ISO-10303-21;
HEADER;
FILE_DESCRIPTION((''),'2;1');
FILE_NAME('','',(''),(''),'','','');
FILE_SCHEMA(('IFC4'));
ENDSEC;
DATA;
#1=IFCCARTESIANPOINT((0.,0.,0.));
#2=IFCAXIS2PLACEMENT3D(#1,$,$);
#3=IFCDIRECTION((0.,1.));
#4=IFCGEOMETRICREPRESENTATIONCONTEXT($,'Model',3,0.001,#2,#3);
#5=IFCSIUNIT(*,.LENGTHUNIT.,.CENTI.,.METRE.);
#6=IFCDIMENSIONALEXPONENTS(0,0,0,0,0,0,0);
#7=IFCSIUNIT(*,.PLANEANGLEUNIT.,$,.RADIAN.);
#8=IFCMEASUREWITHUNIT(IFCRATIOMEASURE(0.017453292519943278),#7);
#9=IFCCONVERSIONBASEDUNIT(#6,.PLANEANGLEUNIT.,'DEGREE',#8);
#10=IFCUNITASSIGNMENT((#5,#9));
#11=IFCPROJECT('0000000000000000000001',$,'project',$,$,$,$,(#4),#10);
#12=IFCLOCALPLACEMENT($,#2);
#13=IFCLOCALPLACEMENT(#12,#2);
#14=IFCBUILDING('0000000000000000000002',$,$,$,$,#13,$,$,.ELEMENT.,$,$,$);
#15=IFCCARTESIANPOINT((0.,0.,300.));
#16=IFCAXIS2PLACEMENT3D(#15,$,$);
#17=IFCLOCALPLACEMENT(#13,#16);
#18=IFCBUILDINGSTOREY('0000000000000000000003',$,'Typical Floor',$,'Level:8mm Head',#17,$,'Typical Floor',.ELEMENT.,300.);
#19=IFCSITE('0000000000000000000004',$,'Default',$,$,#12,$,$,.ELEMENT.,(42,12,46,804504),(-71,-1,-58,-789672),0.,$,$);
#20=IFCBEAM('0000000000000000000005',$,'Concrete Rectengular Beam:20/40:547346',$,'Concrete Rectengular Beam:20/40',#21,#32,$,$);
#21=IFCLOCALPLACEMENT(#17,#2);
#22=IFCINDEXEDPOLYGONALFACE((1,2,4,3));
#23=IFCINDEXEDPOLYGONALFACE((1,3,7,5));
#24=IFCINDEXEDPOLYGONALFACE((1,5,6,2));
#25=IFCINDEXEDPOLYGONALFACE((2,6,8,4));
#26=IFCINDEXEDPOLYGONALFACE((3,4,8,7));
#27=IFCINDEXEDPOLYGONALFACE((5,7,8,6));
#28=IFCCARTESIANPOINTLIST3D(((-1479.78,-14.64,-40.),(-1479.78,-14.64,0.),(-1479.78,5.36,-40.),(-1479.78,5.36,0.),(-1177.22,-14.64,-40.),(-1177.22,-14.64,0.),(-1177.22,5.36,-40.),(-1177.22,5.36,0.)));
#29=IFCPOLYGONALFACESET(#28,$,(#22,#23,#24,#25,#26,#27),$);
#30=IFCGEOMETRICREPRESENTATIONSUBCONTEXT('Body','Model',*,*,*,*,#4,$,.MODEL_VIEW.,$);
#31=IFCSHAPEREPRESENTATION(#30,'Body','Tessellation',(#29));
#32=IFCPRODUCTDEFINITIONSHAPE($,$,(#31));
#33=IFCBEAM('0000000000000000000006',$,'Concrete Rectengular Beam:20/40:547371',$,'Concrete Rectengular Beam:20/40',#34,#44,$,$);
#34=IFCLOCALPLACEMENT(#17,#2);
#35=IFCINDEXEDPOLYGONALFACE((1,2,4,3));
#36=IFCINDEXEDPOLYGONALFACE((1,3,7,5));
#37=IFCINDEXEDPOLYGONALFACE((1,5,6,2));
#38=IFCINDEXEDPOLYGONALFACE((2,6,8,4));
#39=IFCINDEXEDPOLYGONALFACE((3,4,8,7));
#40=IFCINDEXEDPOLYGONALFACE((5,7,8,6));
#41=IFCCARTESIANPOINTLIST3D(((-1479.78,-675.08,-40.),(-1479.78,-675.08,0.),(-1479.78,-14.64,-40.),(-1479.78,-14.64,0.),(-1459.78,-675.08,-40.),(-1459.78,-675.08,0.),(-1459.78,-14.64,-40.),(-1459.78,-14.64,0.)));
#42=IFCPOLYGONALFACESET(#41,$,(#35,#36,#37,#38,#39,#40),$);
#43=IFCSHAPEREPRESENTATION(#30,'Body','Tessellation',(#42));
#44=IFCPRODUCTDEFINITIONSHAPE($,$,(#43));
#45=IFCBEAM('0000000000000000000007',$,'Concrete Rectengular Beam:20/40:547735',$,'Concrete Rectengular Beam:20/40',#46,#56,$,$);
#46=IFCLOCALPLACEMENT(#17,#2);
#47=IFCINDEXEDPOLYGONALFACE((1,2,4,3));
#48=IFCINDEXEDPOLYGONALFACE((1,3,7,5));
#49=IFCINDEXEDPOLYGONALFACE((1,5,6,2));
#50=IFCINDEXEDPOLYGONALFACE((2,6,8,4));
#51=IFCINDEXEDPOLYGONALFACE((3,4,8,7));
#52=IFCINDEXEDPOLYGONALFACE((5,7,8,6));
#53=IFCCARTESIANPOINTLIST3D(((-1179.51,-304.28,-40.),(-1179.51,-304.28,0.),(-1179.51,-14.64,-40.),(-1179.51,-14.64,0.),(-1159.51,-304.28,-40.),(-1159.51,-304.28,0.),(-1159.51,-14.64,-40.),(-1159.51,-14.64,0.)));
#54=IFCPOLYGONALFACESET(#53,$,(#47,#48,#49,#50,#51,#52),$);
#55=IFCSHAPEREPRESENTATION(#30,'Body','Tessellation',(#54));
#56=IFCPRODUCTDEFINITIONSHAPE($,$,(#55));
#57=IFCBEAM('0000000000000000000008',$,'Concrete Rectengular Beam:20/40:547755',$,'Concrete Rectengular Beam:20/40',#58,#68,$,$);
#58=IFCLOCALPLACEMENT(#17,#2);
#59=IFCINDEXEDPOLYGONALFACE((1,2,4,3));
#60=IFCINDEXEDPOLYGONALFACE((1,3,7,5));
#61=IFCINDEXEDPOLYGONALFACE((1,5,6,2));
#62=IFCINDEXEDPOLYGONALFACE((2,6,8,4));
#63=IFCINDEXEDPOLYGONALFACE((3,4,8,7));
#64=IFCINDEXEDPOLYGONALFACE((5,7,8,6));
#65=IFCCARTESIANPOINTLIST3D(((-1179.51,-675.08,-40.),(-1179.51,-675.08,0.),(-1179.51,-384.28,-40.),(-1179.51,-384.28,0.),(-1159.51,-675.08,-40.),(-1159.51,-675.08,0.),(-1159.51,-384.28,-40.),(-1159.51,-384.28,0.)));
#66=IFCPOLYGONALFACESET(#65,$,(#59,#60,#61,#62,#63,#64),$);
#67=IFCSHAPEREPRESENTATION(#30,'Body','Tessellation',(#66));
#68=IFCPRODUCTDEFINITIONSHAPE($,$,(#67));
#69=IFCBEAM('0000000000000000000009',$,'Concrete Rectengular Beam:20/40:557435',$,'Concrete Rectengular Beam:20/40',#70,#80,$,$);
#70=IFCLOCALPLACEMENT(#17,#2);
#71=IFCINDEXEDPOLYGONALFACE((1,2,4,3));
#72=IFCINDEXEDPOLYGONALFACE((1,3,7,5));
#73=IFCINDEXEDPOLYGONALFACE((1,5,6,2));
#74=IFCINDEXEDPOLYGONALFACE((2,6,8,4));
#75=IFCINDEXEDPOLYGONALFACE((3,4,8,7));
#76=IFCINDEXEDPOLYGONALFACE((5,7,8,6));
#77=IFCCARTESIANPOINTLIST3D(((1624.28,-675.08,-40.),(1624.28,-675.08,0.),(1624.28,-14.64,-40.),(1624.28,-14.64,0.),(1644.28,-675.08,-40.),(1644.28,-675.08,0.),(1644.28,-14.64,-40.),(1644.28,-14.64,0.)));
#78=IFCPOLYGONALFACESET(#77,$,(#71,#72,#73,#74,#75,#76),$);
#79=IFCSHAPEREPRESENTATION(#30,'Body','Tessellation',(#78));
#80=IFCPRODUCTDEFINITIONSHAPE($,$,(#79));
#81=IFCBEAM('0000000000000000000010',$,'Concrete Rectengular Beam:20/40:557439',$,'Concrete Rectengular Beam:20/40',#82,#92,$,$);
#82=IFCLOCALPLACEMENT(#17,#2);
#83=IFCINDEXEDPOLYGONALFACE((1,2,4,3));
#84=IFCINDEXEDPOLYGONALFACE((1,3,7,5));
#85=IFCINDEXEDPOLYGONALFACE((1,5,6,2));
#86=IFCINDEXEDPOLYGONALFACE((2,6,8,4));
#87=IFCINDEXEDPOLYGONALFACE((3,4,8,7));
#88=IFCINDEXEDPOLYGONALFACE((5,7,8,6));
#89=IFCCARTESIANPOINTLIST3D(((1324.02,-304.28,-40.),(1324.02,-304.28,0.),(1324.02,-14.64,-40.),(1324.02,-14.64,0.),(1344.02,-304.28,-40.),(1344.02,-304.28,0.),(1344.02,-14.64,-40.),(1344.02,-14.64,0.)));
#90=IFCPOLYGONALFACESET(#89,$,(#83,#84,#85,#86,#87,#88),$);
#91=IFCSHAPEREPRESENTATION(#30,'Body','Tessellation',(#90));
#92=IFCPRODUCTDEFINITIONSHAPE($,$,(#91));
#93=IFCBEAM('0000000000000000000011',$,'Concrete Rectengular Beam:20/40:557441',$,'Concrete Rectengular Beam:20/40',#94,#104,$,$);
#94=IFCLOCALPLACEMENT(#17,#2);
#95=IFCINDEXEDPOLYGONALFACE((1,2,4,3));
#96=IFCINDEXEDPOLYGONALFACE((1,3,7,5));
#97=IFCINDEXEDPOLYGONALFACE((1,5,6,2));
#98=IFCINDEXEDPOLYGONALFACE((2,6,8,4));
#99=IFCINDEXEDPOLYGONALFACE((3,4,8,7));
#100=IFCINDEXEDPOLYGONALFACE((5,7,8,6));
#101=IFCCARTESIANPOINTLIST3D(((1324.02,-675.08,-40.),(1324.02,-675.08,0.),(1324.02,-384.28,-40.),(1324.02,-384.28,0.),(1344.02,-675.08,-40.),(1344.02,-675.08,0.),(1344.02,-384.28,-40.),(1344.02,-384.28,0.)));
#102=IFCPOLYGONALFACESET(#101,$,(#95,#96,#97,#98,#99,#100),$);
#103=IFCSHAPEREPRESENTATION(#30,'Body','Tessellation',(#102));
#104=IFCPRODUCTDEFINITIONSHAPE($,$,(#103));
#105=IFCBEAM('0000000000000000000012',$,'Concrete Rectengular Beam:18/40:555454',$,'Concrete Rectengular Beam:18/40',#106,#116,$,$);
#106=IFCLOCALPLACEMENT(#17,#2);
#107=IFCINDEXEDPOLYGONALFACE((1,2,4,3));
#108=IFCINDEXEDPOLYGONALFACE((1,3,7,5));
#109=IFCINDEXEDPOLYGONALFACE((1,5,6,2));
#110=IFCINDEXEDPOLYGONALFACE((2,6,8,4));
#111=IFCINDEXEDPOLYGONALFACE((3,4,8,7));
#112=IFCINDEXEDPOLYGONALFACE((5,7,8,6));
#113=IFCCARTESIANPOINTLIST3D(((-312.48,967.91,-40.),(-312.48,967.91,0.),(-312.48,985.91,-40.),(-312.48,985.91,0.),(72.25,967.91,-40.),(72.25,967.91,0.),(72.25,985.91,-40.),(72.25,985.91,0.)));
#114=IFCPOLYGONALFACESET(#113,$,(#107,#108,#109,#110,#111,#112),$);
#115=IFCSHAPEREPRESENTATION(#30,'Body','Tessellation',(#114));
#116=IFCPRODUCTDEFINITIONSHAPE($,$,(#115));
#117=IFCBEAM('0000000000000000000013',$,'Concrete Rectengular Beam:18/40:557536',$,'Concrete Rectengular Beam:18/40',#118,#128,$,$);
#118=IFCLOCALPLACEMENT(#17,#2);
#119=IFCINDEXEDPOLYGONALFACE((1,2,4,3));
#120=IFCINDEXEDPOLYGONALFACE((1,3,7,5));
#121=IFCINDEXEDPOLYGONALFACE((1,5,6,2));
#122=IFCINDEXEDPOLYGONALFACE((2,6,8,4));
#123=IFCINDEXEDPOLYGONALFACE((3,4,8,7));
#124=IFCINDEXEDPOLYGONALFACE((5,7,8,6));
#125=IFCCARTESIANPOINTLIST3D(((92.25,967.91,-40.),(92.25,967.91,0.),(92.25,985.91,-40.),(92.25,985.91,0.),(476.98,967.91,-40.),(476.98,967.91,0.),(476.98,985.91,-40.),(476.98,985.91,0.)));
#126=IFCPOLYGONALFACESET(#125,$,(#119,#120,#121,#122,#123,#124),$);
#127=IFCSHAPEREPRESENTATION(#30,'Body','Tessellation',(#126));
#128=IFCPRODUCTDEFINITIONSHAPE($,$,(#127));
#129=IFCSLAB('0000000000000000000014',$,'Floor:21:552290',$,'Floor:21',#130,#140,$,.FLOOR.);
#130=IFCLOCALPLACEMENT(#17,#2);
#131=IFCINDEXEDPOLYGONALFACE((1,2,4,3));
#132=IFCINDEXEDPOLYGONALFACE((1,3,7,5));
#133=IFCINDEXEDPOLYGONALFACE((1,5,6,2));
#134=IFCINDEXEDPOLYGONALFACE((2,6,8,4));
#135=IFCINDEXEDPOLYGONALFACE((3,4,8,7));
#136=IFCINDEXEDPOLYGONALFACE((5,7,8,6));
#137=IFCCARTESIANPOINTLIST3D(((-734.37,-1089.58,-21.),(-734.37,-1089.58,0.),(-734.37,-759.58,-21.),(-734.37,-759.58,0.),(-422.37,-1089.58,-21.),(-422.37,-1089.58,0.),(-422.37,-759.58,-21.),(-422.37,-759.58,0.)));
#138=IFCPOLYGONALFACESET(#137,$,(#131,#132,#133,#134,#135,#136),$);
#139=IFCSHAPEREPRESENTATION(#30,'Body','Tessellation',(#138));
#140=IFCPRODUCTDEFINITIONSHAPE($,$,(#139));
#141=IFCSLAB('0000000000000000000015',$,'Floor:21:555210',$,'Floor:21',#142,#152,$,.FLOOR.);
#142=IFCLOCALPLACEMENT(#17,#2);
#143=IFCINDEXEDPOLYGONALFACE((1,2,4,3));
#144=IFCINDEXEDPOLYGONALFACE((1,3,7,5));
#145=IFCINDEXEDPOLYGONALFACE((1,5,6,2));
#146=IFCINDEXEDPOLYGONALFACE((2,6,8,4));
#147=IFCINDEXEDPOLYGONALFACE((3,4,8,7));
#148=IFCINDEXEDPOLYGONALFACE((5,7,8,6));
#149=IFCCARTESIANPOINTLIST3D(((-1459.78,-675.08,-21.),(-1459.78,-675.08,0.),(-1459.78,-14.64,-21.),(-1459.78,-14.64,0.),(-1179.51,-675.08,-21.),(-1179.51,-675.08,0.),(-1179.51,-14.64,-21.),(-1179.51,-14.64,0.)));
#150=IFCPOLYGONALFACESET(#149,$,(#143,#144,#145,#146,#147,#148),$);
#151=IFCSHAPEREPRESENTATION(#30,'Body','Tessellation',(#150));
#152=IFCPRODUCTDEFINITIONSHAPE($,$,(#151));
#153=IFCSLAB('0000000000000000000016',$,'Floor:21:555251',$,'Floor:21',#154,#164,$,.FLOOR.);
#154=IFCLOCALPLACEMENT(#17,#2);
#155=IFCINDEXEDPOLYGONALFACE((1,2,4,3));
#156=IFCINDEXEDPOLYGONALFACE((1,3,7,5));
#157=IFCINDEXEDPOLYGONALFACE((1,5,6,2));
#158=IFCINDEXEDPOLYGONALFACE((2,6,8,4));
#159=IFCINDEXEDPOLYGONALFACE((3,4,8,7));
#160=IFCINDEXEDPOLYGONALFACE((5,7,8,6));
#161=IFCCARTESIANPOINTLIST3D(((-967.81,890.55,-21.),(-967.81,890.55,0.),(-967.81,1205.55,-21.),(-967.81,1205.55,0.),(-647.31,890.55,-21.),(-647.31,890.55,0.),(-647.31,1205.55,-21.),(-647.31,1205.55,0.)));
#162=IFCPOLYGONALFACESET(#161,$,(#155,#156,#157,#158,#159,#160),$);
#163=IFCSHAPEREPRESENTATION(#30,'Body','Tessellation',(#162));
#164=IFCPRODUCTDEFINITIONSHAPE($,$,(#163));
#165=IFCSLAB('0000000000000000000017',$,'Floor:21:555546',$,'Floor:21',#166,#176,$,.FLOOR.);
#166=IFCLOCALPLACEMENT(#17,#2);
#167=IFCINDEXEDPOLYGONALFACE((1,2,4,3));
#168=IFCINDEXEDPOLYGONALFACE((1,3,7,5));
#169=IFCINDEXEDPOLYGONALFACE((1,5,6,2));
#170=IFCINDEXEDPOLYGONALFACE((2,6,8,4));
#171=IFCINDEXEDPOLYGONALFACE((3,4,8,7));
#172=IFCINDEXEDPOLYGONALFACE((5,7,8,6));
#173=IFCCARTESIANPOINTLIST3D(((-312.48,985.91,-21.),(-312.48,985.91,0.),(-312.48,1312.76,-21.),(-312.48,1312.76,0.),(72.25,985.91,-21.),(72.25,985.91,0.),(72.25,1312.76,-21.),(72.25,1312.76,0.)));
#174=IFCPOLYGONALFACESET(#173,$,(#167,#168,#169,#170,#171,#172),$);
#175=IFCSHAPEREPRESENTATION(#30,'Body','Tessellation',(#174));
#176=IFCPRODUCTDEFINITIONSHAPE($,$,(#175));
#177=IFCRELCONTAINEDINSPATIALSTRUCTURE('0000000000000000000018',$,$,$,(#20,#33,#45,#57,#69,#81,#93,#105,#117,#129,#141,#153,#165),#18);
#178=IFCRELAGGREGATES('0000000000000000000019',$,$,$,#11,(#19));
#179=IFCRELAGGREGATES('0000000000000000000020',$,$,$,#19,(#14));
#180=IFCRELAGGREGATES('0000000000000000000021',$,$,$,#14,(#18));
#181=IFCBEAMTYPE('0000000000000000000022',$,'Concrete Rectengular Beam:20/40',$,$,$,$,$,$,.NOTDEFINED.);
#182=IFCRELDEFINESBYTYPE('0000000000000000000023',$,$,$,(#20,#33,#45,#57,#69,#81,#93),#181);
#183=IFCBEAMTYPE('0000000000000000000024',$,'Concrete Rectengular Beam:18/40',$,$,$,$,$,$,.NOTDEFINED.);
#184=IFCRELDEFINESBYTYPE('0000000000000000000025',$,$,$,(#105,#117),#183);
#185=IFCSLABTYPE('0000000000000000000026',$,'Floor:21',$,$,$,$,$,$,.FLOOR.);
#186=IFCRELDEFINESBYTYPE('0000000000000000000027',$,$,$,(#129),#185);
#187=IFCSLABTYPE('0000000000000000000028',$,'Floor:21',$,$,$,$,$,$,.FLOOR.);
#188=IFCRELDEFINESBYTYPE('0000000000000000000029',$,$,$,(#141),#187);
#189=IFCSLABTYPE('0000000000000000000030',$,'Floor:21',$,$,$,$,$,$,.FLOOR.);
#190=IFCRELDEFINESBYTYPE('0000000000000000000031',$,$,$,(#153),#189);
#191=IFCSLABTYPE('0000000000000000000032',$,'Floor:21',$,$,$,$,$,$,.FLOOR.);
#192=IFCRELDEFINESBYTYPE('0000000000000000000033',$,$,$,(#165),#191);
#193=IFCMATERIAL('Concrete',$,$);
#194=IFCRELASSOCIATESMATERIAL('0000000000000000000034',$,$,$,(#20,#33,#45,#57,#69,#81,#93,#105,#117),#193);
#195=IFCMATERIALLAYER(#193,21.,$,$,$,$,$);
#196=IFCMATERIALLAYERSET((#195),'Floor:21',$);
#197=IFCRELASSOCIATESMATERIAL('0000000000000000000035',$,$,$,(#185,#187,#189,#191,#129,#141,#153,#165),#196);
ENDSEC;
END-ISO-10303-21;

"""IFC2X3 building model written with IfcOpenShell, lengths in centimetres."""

from ifc_helpers import new_model, entity, si_unit, converted_unit, direction, frame, frame_2d, origin, origin_2d_with_axis, place, context, subcontext, project, spatial, rectangle, extrude, material, layer, layer_set, layer_usage, type_object, element, save


model = new_model("IFC2X3")

# Units and contexts
model_context = context("Model", 3, precision=0.001, world=origin(), true_north=direction((0.0, 1.0)))
body_context = subcontext(model_context, "Body", "Model", "MODEL_VIEW")
ifc_project = project(units=[si_unit("LENGTHUNIT", "METRE", prefix="CENTI"), converted_unit("PLANEANGLEUNIT", "DEGREE", entity("IfcRatioMeasure", 0.017453292519943278), si_unit("PLANEANGLEUNIT", "RADIAN"), dimensions=[0, 0, 0, 0, 0, 0, 0])], contexts=[model_context])

# Site, building, storey
site_placement = place(None, origin())
site = spatial("IfcSite", under=ifc_project, at=site_placement, Name="Default", CompositionType="ELEMENT", RefLatitude=(42, 12, 46, 804504), RefLongitude=(-71, -1, -58, -789672), RefElevation=0.0)
building_placement = place(site_placement, origin())
building = spatial("IfcBuilding", under=site, at=building_placement, CompositionType="ELEMENT")
storey_placement = place(building_placement, frame((0.0, 0.0, 300.0)))
storey = spatial("IfcBuildingStorey", under=building, at=storey_placement, Name="Typical Floor", ObjectType="Level:8mm Head", LongName="Typical Floor", CompositionType="ELEMENT", Elevation=300.0)

# Beams
ifc_material = material(Name="Concrete")
beam_type_1 = type_object("IfcBeamType", Name="Concrete Rectengular Beam:20/40", PredefinedType="NOTDEFINED")
beam_1_placement = place(storey_placement, frame((-1177.22, -4.64, 0.0), z_axis=(0.0, 0.0, 1.0), x_axis=(-1.0, 0.0, 0.0)))
element("IfcBeam", 1, at=beam_1_placement, inside=storey, type_object=beam_type_1, material=ifc_material, Name="Concrete Rectengular Beam:20/40:547346", ObjectType="Concrete Rectengular Beam:20/40", context=body_context, shape_type="SweptSolid", body=[
    extrude(rectangle(XDim=40.0, YDim=20.0, at=frame_2d((0.0, 0.0), x_axis=(1.0, 0.0))), frame((0.0, 0.0, -20.0), z_axis=(1.0, 0.0, 0.0), x_axis=(0.0, 0.0, -1.0)), (0.0, 0.0, 1.0), 302.56),
])
beam_2_placement = place(storey_placement, frame((-1469.78, -4.64, 0.0), z_axis=(0.0, 0.0, 1.0), x_axis=(0.0, -1.0, 0.0)))
element("IfcBeam", 2, at=beam_2_placement, inside=storey, type_object=beam_type_1, material=ifc_material, Name="Concrete Rectengular Beam:20/40:547371", ObjectType="Concrete Rectengular Beam:20/40", context=body_context, shape_type="SweptSolid", body=[
    extrude(rectangle(XDim=40.0, YDim=20.0, at=frame_2d((0.0, 0.0), x_axis=(1.0, 0.0))), frame((10.0, 0.0, -20.0), z_axis=(1.0, 0.0, 0.0), x_axis=(0.0, 0.0, -1.0)), (0.0, 0.0, 1.0), 660.45),
])
beam_3_placement = place(storey_placement, frame((-1169.51, -4.64, 0.0), z_axis=(0.0, 0.0, 1.0), x_axis=(0.0, -1.0, 0.0)))
element("IfcBeam", 3, at=beam_3_placement, inside=storey, type_object=beam_type_1, material=ifc_material, Name="Concrete Rectengular Beam:20/40:547735", ObjectType="Concrete Rectengular Beam:20/40", context=body_context, shape_type="SweptSolid", body=[
    extrude(rectangle(XDim=40.0, YDim=20.0, at=frame_2d((0.0, 0.0), x_axis=(1.0, 0.0))), frame((10.0, 0.0, -20.0), z_axis=(1.0, 0.0, 0.0), x_axis=(0.0, 0.0, -1.0)), (0.0, 0.0, 1.0), 289.65),
])
beam_4_placement = place(storey_placement, frame((-1169.51, -344.28, 0.0), z_axis=(0.0, 0.0, 1.0), x_axis=(0.0, -1.0, 0.0)))
element("IfcBeam", 4, at=beam_4_placement, inside=storey, type_object=beam_type_1, material=ifc_material, Name="Concrete Rectengular Beam:20/40:547755", ObjectType="Concrete Rectengular Beam:20/40", context=body_context, shape_type="SweptSolid", body=[
    extrude(rectangle(XDim=40.0, YDim=20.0, at=frame_2d((0.0, 0.0), x_axis=(1.0, 0.0))), frame((40.0, 0.0, -20.0), z_axis=(1.0, 0.0, 0.0), x_axis=(0.0, 0.0, -1.0)), (0.0, 0.0, 1.0), 290.8),
])
beam_5_placement = place(storey_placement, frame((1634.28, -4.64, 0.0), z_axis=(0.0, 0.0, 1.0), x_axis=(0.0, -1.0, 0.0)))
element("IfcBeam", 5, at=beam_5_placement, inside=storey, type_object=beam_type_1, material=ifc_material, Name="Concrete Rectengular Beam:20/40:557435", ObjectType="Concrete Rectengular Beam:20/40", context=body_context, shape_type="SweptSolid", body=[
    extrude(rectangle(XDim=40.0, YDim=20.0, at=frame_2d((0.0, 0.0), x_axis=(1.0, 0.0))), frame((10.0, 0.0, -20.0), z_axis=(1.0, 0.0, 0.0), x_axis=(0.0, 0.0, -1.0)), (0.0, 0.0, 1.0), 660.45),
])
beam_6_placement = place(storey_placement, frame((1334.02, -4.64, 0.0), z_axis=(0.0, 0.0, 1.0), x_axis=(0.0, -1.0, 0.0)))
element("IfcBeam", 6, at=beam_6_placement, inside=storey, type_object=beam_type_1, material=ifc_material, Name="Concrete Rectengular Beam:20/40:557439", ObjectType="Concrete Rectengular Beam:20/40", context=body_context, shape_type="SweptSolid", body=[
    extrude(rectangle(XDim=40.0, YDim=20.0, at=frame_2d((0.0, 0.0), x_axis=(1.0, 0.0))), frame((10.0, 0.0, -20.0), z_axis=(1.0, 0.0, 0.0), x_axis=(0.0, 0.0, -1.0)), (0.0, 0.0, 1.0), 289.65),
])
beam_7_placement = place(storey_placement, frame((1334.02, -344.28, 0.0), z_axis=(0.0, 0.0, 1.0), x_axis=(0.0, -1.0, 0.0)))
element("IfcBeam", 7, at=beam_7_placement, inside=storey, type_object=beam_type_1, material=ifc_material, Name="Concrete Rectengular Beam:20/40:557441", ObjectType="Concrete Rectengular Beam:20/40", context=body_context, shape_type="SweptSolid", body=[
    extrude(rectangle(XDim=40.0, YDim=20.0, at=frame_2d((0.0, 0.0), x_axis=(1.0, 0.0))), frame((40.0, 0.0, -20.0), z_axis=(1.0, 0.0, 0.0), x_axis=(0.0, 0.0, -1.0)), (0.0, 0.0, 1.0), 290.8),
])
beam_type_2 = type_object("IfcBeamType", Name="Concrete Rectengular Beam:18/40", PredefinedType="NOTDEFINED")
beam_8_placement = place(storey_placement, frame((-321.48, 976.91, 0.0)))
element("IfcBeam", 8, at=beam_8_placement, inside=storey, type_object=beam_type_2, material=ifc_material, Name="Concrete Rectengular Beam:18/40:555454", ObjectType="Concrete Rectengular Beam:18/40", context=body_context, shape_type="SweptSolid", body=[
    extrude(rectangle(XDim=40.0, YDim=18.0, at=frame_2d((0.0, 0.0), x_axis=(1.0, 0.0))), frame((9.0, 0.0, -20.0), z_axis=(1.0, 0.0, 0.0), x_axis=(0.0, 0.0, -1.0)), (0.0, 0.0, 1.0), 384.73),
])
beam_9_placement = place(storey_placement, frame((485.98, 976.91, 0.0), z_axis=(0.0, 0.0, 1.0), x_axis=(-1.0, 0.0, 0.0)))
element("IfcBeam", 9, at=beam_9_placement, inside=storey, type_object=beam_type_2, material=ifc_material, Name="Concrete Rectengular Beam:18/40:557536", ObjectType="Concrete Rectengular Beam:18/40", context=body_context, shape_type="SweptSolid", body=[
    extrude(rectangle(XDim=40.0, YDim=18.0, at=frame_2d((0.0, 0.0), x_axis=(1.0, 0.0))), frame((9.0, 0.0, -20.0), z_axis=(1.0, 0.0, 0.0), x_axis=(0.0, 0.0, -1.0)), (0.0, 0.0, 1.0), 384.73),
])

# Slabs
ifc_layer = layer(ifc_material, 21.0)
ifc_layer_set = layer_set([ifc_layer], Name="Floor:21")
ifc_layer_usage_1 = layer_usage(ifc_layer_set, "AXIS3", "POSITIVE", 0.0)
slab_type_1 = type_object("IfcSlabType", Name="Floor:21", PredefinedType="FLOOR", material=ifc_layer_set)
slab_1_placement = place(storey_placement, origin())
element("IfcSlab", 10, at=slab_1_placement, inside=storey, type_object=slab_type_1, material=ifc_layer_usage_1, Name="Floor:21:552290", ObjectType="Floor:21", PredefinedType="FLOOR", context=body_context, shape_type="SweptSolid", body=[
    extrude(rectangle(XDim=330.0, YDim=312.0, at=frame_2d((0.0, 0.0), x_axis=(1.0, 0.0))), frame((-578.37, -924.58, 0.0), z_axis=(0.0, 0.0, -1.0), x_axis=(0.0, 1.0, 0.0)), (0.0, 0.0, 1.0), 21.0),
])
ifc_layer_usage_2 = layer_usage(ifc_layer_set, "AXIS3", "POSITIVE", 0.0)
slab_type_2 = type_object("IfcSlabType", Name="Floor:21", PredefinedType="FLOOR", material=ifc_layer_set)
slab_2_placement = place(storey_placement, origin())
element("IfcSlab", 11, at=slab_2_placement, inside=storey, type_object=slab_type_2, material=ifc_layer_usage_2, Name="Floor:21:555210", ObjectType="Floor:21", PredefinedType="FLOOR", context=body_context, shape_type="SweptSolid", body=[
    extrude(rectangle(XDim=660.45, YDim=280.26, at=frame_2d((0.0, 0.0), x_axis=(1.0, 0.0))), frame((-1319.64, -344.86, 0.0), z_axis=(0.0, 0.0, -1.0), x_axis=(0.0, 1.0, 0.0)), (0.0, 0.0, 1.0), 21.0),
])
ifc_layer_usage_3 = layer_usage(ifc_layer_set, "AXIS3", "POSITIVE", 0.0)
slab_type_3 = type_object("IfcSlabType", Name="Floor:21", PredefinedType="FLOOR", material=ifc_layer_set)
slab_3_placement = place(storey_placement, origin())
element("IfcSlab", 12, at=slab_3_placement, inside=storey, type_object=slab_type_3, material=ifc_layer_usage_3, Name="Floor:21:555251", ObjectType="Floor:21", PredefinedType="FLOOR", context=body_context, shape_type="SweptSolid", body=[
    extrude(rectangle(XDim=315.0, YDim=320.5, at=frame_2d((0.0, 0.0), x_axis=(1.0, 0.0))), frame((-807.56, 1048.05, 0.0), z_axis=(0.0, 0.0, -1.0), x_axis=(0.0, 1.0, 0.0)), (0.0, 0.0, 1.0), 21.0),
])
ifc_layer_usage_4 = layer_usage(ifc_layer_set, "AXIS3", "POSITIVE", 0.0)
slab_type_4 = type_object("IfcSlabType", Name="Floor:21", PredefinedType="FLOOR", material=ifc_layer_set)
slab_4_placement = place(storey_placement, origin())
element("IfcSlab", 13, at=slab_4_placement, inside=storey, type_object=slab_type_4, material=ifc_layer_usage_4, Name="Floor:21:555546", ObjectType="Floor:21", PredefinedType="FLOOR", context=body_context, shape_type="SweptSolid", body=[
    extrude(rectangle(XDim=326.85, YDim=384.73, at=origin_2d_with_axis()), frame((-120.11, 1149.33, 0.0), z_axis=(0.0, 0.0, -1.0), x_axis=(0.0, 1.0, 0.0)), (0.0, 0.0, 1.0), 21.0),
])

save(model, "model.ifc")
